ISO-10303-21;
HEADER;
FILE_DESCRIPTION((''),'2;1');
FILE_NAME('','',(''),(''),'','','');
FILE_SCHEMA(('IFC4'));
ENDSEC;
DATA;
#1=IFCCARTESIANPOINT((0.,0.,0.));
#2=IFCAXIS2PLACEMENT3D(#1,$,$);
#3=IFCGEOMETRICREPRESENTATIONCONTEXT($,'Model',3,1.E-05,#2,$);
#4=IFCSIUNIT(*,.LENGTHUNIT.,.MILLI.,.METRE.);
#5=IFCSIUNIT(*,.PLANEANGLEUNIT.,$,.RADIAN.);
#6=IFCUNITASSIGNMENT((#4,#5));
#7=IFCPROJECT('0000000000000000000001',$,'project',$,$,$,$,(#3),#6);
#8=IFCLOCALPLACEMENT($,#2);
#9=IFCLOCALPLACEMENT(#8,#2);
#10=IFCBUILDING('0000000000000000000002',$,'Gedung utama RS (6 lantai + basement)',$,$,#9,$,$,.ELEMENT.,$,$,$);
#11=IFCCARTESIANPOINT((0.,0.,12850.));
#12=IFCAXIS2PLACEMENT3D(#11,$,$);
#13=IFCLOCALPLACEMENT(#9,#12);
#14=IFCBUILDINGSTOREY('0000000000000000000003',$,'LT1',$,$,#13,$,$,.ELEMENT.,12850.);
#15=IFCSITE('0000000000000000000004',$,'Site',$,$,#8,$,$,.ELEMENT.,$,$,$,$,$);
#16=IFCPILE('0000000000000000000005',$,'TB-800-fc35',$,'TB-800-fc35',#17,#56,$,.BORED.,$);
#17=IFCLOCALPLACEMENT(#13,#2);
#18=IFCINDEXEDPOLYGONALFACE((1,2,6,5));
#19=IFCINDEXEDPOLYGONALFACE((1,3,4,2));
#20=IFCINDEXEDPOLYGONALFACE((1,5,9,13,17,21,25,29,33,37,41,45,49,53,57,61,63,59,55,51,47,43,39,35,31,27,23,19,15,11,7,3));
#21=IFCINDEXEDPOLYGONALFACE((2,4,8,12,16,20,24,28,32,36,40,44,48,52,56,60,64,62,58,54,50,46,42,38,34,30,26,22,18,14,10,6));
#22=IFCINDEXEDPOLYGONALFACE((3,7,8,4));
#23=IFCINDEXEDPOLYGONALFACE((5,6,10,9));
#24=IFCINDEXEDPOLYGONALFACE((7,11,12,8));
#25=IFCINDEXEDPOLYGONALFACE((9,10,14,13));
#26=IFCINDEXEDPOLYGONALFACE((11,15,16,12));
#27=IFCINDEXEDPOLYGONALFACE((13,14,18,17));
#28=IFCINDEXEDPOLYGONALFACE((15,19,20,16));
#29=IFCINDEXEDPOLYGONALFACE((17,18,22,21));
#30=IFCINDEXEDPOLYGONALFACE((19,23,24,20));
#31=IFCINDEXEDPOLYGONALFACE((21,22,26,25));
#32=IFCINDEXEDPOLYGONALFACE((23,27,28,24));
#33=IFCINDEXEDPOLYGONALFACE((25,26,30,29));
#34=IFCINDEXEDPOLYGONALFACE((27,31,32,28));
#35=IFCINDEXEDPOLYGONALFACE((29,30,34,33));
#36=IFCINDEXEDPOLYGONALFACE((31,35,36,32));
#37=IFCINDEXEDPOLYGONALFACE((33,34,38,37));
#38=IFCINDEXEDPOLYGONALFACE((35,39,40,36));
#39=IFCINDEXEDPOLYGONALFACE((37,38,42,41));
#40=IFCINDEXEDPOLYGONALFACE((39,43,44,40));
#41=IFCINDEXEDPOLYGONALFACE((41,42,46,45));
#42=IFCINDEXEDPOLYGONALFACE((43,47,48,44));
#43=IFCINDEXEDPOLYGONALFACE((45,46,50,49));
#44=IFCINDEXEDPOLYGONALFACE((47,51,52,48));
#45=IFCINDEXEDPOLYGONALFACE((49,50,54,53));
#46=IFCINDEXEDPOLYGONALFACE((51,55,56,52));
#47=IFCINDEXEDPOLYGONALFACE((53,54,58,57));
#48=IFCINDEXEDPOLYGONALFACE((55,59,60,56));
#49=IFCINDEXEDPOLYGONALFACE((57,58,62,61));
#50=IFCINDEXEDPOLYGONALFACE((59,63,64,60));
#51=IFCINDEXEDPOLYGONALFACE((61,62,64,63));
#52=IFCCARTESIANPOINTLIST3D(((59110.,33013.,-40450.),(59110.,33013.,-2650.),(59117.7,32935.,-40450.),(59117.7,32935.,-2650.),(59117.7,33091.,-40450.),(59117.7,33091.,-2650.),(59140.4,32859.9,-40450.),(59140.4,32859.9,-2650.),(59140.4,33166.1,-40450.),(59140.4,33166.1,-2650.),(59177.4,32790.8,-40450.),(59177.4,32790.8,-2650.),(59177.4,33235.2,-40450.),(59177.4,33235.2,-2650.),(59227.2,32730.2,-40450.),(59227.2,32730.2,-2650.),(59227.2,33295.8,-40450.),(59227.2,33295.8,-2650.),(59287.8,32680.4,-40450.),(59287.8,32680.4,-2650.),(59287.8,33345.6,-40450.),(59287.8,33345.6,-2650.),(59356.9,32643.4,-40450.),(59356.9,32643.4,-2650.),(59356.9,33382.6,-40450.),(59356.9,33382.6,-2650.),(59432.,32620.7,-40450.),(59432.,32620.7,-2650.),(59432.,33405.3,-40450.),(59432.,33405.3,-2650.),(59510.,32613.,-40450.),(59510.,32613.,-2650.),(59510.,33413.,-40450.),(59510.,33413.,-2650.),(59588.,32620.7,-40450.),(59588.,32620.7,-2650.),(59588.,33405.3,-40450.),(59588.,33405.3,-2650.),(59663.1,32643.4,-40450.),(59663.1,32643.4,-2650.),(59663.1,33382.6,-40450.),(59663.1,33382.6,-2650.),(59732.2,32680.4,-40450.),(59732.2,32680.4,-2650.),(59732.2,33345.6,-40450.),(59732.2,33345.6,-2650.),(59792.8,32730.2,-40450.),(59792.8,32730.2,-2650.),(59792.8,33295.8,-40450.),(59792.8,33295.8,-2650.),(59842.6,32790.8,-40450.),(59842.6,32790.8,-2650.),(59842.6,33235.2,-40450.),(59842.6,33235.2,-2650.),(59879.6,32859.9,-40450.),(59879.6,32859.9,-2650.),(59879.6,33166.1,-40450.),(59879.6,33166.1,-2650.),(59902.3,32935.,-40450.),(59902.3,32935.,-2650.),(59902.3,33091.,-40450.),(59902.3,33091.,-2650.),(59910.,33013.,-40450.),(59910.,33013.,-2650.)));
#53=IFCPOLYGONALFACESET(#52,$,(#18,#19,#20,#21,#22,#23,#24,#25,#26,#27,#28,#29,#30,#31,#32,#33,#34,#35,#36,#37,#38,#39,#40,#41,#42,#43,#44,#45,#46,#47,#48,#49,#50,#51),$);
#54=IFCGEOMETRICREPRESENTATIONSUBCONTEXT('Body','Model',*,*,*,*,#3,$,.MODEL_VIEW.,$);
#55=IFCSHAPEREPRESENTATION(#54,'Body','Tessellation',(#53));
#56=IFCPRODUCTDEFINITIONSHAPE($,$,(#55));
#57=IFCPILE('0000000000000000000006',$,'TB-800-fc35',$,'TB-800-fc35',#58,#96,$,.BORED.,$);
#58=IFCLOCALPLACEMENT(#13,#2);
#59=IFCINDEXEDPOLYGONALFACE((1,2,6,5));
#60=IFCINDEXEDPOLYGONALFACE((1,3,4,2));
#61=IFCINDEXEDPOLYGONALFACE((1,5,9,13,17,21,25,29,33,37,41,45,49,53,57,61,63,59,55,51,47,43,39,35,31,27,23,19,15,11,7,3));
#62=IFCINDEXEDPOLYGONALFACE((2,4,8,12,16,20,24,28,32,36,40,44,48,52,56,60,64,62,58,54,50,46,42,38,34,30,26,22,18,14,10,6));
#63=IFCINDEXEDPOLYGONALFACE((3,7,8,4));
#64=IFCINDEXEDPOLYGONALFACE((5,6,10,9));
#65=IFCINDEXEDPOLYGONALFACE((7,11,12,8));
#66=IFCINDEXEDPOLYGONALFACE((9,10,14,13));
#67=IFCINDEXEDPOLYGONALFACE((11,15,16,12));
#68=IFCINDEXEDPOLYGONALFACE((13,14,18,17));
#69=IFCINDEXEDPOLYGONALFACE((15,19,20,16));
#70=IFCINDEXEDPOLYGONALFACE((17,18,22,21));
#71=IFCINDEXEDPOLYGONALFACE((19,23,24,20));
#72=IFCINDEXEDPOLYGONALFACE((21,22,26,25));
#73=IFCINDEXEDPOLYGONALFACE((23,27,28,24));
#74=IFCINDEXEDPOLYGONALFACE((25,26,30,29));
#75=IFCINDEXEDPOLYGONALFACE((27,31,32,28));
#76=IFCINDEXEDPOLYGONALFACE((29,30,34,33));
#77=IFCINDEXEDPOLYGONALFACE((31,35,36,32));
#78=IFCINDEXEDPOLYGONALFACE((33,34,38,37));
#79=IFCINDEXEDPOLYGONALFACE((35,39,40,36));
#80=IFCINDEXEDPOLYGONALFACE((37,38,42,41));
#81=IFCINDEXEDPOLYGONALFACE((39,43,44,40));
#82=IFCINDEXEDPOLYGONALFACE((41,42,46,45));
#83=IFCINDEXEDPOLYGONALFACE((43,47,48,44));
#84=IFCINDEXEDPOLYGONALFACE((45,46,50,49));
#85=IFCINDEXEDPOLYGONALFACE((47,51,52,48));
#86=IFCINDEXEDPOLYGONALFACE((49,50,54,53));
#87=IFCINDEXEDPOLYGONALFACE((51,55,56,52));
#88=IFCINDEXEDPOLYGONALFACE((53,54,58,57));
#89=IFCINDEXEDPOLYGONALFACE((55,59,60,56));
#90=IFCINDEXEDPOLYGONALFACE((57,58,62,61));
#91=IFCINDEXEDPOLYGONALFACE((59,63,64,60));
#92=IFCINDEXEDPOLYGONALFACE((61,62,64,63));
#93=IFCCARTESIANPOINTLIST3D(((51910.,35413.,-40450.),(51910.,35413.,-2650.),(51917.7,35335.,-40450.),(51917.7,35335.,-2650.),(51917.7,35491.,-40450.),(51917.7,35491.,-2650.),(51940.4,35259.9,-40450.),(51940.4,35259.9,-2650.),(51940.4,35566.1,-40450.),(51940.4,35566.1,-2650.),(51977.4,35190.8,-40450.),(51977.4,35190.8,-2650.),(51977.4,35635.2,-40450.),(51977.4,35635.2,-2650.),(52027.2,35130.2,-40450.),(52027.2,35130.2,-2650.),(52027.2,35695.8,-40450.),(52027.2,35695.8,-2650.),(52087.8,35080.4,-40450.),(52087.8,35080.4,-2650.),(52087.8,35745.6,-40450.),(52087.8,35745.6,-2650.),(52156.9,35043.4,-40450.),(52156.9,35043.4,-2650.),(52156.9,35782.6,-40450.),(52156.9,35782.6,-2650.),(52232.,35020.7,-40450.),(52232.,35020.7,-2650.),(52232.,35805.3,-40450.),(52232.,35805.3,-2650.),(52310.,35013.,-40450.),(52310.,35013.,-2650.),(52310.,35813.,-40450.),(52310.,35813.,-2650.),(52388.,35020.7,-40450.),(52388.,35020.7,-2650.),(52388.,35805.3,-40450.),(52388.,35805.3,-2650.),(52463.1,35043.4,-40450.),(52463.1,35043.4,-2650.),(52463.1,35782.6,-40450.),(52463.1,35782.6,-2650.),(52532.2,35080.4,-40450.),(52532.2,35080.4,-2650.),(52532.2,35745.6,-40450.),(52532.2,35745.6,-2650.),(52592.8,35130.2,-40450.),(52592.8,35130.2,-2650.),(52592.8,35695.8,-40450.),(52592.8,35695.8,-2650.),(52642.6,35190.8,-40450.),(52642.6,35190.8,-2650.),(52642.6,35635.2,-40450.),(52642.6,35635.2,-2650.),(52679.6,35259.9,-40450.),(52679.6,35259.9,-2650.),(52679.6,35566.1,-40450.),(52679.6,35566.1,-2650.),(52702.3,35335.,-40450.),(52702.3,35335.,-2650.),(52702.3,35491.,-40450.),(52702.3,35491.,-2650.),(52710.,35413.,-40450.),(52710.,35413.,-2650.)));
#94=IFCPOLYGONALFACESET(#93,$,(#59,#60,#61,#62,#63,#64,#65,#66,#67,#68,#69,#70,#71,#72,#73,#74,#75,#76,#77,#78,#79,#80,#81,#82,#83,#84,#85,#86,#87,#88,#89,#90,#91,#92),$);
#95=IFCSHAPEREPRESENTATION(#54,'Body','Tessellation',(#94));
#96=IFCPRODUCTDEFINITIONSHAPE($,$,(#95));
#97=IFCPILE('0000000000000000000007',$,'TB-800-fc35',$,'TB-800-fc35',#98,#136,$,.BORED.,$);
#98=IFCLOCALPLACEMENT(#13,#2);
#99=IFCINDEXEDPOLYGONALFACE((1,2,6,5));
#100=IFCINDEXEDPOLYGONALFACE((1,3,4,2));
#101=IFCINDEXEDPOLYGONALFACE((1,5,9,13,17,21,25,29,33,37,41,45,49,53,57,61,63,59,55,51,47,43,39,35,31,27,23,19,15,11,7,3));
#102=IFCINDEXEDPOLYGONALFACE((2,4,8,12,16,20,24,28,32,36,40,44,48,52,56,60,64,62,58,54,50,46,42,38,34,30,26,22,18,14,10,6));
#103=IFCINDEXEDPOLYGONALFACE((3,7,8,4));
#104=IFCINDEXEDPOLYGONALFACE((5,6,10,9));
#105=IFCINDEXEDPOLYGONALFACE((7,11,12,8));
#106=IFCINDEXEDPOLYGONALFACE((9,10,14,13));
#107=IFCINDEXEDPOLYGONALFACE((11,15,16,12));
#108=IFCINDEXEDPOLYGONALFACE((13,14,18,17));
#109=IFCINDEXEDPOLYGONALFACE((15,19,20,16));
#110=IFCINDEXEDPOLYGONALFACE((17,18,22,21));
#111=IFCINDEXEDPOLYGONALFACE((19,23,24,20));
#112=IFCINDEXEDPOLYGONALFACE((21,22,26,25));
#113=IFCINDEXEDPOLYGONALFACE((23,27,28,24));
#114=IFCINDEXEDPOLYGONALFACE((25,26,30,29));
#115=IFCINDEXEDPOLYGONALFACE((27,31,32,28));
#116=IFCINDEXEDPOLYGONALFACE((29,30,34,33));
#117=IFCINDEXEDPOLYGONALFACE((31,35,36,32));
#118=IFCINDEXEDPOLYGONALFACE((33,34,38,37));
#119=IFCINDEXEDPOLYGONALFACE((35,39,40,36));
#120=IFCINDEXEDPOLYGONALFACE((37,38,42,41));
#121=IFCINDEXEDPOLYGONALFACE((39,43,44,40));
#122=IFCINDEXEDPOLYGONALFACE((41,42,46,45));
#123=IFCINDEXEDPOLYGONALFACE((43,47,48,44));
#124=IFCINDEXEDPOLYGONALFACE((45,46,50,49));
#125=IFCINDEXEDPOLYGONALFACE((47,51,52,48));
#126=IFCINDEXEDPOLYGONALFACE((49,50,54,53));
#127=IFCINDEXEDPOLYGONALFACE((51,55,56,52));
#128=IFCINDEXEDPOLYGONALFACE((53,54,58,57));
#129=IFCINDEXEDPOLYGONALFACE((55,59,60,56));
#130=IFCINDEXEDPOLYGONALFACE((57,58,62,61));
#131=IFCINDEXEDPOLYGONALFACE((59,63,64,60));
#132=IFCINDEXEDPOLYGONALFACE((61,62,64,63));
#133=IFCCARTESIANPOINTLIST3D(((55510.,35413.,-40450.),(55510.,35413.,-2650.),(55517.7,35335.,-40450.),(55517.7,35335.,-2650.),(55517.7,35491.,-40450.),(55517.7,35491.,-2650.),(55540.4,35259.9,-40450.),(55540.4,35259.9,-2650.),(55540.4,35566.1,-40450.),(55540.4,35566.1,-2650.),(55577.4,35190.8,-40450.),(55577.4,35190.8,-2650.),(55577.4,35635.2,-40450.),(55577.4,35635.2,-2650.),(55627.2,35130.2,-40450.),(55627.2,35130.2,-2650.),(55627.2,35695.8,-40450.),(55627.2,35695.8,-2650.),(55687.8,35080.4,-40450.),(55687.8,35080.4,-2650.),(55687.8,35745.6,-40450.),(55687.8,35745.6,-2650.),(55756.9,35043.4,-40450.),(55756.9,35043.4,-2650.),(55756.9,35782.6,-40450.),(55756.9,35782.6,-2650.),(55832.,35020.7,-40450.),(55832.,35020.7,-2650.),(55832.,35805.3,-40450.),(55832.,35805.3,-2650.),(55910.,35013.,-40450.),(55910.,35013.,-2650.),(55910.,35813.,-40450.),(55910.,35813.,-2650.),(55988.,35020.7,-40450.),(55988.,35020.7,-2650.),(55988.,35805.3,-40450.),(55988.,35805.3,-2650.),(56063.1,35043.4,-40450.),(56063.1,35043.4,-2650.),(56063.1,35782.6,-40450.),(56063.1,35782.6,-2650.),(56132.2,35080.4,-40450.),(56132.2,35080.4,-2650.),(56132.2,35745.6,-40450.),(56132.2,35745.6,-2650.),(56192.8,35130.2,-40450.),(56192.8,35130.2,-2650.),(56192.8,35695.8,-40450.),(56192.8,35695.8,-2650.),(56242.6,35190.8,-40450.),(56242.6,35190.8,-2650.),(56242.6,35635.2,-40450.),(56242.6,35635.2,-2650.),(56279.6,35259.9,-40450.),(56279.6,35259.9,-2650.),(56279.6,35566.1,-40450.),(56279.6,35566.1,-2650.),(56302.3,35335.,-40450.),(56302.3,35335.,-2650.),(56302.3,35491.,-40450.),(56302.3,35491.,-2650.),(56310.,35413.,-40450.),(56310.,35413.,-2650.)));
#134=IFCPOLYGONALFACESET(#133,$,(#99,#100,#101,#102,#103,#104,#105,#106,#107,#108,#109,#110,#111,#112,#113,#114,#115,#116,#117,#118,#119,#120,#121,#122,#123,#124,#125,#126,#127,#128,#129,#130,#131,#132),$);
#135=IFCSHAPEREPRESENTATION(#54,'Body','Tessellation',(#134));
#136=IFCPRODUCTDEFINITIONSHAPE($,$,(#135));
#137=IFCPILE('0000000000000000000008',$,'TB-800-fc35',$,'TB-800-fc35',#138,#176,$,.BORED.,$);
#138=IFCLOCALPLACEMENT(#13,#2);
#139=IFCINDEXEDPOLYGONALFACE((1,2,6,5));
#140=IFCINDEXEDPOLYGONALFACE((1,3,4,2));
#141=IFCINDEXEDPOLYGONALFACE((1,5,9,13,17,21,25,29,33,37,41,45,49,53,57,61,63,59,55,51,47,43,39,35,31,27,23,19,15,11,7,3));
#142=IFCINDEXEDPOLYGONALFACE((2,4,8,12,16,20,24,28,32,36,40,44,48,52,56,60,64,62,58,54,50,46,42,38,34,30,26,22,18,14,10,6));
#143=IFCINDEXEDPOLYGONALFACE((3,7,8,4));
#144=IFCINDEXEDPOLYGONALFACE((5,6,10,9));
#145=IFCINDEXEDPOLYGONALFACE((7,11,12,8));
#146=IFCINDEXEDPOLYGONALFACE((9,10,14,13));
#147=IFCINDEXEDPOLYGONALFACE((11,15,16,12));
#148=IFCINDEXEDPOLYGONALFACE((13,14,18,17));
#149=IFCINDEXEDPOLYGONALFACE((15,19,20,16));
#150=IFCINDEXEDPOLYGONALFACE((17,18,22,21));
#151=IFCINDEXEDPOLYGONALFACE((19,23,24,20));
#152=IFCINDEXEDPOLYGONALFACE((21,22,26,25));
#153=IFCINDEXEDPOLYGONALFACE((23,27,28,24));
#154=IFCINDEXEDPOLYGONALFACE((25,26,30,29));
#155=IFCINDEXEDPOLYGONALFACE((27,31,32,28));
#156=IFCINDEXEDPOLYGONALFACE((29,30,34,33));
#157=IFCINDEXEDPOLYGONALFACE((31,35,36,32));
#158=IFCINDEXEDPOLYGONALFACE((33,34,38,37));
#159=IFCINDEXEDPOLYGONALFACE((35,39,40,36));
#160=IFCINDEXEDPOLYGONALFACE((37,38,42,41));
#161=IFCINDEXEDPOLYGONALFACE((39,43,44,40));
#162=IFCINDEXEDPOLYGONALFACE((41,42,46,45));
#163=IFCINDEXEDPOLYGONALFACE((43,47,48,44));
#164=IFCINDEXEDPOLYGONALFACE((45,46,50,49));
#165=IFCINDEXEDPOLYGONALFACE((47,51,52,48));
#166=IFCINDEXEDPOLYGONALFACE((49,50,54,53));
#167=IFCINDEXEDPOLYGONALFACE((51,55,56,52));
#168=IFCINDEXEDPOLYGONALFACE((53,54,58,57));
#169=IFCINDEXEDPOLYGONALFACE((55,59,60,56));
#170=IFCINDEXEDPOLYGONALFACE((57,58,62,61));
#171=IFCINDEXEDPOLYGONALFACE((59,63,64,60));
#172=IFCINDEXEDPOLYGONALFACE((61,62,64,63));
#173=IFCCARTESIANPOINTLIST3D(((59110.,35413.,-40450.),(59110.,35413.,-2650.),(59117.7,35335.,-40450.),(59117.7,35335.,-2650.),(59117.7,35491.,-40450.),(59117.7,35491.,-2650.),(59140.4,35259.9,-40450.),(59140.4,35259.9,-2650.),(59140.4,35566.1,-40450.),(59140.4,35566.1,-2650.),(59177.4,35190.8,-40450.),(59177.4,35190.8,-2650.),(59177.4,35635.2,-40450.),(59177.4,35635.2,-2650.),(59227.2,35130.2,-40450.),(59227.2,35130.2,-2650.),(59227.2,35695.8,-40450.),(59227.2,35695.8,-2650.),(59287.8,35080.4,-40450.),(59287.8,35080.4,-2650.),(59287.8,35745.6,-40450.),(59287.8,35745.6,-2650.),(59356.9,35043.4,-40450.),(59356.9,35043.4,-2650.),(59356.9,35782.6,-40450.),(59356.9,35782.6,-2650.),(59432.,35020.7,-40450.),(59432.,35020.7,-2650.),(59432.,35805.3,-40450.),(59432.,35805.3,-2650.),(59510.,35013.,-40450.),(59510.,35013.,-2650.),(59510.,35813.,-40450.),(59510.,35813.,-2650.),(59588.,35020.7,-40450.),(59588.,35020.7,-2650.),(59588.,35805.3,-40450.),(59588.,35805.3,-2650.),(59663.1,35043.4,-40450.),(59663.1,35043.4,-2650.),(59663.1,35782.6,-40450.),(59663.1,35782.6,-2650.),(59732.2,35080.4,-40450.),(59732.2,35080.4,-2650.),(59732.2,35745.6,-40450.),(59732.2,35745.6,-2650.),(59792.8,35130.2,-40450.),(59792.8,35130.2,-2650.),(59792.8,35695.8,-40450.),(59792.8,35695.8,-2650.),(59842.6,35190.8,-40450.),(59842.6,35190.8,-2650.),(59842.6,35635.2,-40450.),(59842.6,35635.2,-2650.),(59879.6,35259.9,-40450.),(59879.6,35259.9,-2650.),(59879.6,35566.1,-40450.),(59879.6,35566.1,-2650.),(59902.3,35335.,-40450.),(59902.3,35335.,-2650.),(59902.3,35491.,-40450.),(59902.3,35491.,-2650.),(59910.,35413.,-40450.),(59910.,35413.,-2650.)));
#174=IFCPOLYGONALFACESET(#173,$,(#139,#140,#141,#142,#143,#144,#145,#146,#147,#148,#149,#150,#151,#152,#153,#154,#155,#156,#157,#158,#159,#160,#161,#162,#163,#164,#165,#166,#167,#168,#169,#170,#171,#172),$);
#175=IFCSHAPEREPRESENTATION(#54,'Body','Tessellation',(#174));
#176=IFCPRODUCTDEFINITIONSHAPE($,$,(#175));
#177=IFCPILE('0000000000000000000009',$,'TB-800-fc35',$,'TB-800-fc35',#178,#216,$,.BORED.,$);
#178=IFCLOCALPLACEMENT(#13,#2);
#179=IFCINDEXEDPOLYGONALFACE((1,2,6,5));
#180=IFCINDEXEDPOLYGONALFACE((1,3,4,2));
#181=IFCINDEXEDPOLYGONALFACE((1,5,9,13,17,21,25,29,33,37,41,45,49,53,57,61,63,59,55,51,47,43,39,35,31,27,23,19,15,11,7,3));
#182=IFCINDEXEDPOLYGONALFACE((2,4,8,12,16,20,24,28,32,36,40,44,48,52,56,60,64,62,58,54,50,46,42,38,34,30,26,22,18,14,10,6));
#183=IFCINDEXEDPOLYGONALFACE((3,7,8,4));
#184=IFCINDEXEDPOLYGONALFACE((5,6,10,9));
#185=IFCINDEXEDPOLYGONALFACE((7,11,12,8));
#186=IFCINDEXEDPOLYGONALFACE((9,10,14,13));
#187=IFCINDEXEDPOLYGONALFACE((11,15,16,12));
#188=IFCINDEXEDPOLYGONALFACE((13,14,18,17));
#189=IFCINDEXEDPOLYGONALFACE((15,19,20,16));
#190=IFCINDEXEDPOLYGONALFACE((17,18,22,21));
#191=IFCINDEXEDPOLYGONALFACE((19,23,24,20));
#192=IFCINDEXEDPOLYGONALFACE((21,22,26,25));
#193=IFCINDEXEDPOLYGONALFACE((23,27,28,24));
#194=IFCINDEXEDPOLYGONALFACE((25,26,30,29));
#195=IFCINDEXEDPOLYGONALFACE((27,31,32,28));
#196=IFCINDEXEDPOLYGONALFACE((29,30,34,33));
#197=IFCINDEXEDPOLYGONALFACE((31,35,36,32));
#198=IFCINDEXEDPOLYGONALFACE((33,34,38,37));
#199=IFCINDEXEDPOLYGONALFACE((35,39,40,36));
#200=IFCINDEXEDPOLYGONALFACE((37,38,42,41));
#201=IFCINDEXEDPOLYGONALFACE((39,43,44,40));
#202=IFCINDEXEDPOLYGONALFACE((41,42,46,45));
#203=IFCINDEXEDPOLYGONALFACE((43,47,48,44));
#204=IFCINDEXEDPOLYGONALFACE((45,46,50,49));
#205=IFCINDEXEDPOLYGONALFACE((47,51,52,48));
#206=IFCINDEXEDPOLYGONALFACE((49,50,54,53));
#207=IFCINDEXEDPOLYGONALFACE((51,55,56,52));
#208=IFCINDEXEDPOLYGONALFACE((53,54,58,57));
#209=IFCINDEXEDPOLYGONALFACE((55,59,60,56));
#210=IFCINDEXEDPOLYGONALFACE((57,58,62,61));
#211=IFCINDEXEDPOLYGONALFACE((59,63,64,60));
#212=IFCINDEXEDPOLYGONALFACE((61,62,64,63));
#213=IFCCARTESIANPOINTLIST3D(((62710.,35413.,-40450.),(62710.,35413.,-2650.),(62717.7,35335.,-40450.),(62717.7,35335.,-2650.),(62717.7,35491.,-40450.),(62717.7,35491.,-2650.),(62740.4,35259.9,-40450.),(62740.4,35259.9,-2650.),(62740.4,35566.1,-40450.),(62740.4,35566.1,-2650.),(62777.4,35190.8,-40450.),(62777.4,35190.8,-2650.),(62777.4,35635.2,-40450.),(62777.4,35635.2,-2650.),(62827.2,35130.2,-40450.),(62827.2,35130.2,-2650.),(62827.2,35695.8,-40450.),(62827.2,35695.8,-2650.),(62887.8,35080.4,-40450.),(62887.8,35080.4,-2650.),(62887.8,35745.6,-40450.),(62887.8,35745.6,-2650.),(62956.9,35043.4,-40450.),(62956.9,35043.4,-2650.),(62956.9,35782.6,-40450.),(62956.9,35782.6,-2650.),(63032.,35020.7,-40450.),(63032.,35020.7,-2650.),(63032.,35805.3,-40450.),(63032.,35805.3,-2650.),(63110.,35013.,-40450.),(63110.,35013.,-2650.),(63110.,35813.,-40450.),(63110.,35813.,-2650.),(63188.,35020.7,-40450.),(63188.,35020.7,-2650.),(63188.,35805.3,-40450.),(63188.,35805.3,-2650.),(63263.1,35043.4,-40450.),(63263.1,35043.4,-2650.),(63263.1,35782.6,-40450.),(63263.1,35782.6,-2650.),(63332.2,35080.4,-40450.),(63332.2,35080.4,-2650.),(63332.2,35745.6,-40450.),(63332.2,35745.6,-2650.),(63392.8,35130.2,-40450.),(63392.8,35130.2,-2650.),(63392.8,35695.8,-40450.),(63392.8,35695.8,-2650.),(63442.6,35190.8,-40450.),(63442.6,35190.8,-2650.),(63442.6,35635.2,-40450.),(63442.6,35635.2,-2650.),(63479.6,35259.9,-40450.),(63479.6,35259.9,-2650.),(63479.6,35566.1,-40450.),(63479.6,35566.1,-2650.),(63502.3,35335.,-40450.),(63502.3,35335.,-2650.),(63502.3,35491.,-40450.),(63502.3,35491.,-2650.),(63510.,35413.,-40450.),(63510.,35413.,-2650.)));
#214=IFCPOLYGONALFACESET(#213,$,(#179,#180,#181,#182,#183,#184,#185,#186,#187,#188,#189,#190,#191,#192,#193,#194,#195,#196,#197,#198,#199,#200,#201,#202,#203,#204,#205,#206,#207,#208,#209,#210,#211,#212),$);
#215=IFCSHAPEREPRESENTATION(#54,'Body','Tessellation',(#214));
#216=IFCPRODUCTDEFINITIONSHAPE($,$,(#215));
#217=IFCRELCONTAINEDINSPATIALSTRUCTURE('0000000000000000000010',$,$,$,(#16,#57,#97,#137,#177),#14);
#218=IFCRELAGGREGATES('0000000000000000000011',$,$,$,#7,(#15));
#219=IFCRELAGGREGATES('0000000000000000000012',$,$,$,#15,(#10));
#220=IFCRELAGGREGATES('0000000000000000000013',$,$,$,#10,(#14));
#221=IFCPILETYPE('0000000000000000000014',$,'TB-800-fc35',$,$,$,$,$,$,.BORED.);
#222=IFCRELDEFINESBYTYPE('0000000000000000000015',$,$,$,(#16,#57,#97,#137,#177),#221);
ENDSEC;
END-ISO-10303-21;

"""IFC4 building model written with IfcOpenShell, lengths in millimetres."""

from ifc_helpers import new_model, si_unit, frame, origin, origin_2d, place, context, subcontext, project, spatial, circle, extrude, material_profile, profile_set, profile_usage, type_object, element, save


model = new_model("IFC4")

# Units and contexts
model_context = context("Model", 3, precision=1e-05, world=origin())
body_context = subcontext(model_context, "Body", "Model", "MODEL_VIEW")
ifc_project = project(units=[si_unit("LENGTHUNIT", "METRE", prefix="MILLI"), si_unit("PLANEANGLEUNIT", "RADIAN")], contexts=[model_context])

# Site, building, storey
site_placement = place(None, origin())
site = spatial("IfcSite", under=ifc_project, at=site_placement, Name="Site", CompositionType="ELEMENT")
building_placement = place(site_placement, origin())
building = spatial("IfcBuilding", under=site, at=building_placement, Name="Gedung utama RS (6 lantai + basement)", CompositionType="ELEMENT")
storey_placement = place(building_placement, frame((0.0, 0.0, 12850.0)))
storey = spatial("IfcBuildingStorey", under=building, at=storey_placement, Name="LT1", CompositionType="ELEMENT", Elevation=12850.0)

# Piles
ifc_material_profile = material_profile(None, circle(Radius=400.0, at=origin_2d()), Name="TB-800-fc35")
ifc_profile_set = profile_set([ifc_material_profile], Name="TB-800-fc35")
ifc_profile_usage = profile_usage(ifc_profile_set, cardinal=5)
pile_type = type_object("IfcPileType", Name="TB-800-fc35", PredefinedType="BORED", material=ifc_profile_set)
for number, where, z_axis, x_axis, name in (
    (1, (59510.0, 33013.0, -40450.0), (0.0, 0.0, 1.0), (1.0, 0.0, 0.0), "TB-800-fc35"),
    (2, (52310.0, 35413.0, -40450.0), (0.0, 0.0, 1.0), (1.0, 0.0, 0.0), "TB-800-fc35"),
    (3, (55910.0, 35413.0, -40450.0), (0.0, 0.0, 1.0), (1.0, 0.0, 0.0), "TB-800-fc35"),
    (4, (59510.0, 35413.0, -40450.0), (0.0, 0.0, 1.0), (1.0, 0.0, 0.0), "TB-800-fc35"),
    (5, (63110.0, 35413.0, -40450.0), (0.0, 0.0, 1.0), (1.0, 0.0, 0.0), "TB-800-fc35"),
):
    element("IfcPile", number, at=place(storey_placement, frame(where, z_axis=z_axis, x_axis=x_axis)), inside=storey, type_object=pile_type, material=ifc_profile_usage, Name=name, ObjectType="TB-800-fc35", PredefinedType="BORED", context=body_context, shape_type="SweptSolid", body=[
        extrude(circle(Radius=400.0, at=origin_2d()), origin(), (0.0, 0.0, 1.0), 37800.0),
    ])

save(model, "model.ifc")
